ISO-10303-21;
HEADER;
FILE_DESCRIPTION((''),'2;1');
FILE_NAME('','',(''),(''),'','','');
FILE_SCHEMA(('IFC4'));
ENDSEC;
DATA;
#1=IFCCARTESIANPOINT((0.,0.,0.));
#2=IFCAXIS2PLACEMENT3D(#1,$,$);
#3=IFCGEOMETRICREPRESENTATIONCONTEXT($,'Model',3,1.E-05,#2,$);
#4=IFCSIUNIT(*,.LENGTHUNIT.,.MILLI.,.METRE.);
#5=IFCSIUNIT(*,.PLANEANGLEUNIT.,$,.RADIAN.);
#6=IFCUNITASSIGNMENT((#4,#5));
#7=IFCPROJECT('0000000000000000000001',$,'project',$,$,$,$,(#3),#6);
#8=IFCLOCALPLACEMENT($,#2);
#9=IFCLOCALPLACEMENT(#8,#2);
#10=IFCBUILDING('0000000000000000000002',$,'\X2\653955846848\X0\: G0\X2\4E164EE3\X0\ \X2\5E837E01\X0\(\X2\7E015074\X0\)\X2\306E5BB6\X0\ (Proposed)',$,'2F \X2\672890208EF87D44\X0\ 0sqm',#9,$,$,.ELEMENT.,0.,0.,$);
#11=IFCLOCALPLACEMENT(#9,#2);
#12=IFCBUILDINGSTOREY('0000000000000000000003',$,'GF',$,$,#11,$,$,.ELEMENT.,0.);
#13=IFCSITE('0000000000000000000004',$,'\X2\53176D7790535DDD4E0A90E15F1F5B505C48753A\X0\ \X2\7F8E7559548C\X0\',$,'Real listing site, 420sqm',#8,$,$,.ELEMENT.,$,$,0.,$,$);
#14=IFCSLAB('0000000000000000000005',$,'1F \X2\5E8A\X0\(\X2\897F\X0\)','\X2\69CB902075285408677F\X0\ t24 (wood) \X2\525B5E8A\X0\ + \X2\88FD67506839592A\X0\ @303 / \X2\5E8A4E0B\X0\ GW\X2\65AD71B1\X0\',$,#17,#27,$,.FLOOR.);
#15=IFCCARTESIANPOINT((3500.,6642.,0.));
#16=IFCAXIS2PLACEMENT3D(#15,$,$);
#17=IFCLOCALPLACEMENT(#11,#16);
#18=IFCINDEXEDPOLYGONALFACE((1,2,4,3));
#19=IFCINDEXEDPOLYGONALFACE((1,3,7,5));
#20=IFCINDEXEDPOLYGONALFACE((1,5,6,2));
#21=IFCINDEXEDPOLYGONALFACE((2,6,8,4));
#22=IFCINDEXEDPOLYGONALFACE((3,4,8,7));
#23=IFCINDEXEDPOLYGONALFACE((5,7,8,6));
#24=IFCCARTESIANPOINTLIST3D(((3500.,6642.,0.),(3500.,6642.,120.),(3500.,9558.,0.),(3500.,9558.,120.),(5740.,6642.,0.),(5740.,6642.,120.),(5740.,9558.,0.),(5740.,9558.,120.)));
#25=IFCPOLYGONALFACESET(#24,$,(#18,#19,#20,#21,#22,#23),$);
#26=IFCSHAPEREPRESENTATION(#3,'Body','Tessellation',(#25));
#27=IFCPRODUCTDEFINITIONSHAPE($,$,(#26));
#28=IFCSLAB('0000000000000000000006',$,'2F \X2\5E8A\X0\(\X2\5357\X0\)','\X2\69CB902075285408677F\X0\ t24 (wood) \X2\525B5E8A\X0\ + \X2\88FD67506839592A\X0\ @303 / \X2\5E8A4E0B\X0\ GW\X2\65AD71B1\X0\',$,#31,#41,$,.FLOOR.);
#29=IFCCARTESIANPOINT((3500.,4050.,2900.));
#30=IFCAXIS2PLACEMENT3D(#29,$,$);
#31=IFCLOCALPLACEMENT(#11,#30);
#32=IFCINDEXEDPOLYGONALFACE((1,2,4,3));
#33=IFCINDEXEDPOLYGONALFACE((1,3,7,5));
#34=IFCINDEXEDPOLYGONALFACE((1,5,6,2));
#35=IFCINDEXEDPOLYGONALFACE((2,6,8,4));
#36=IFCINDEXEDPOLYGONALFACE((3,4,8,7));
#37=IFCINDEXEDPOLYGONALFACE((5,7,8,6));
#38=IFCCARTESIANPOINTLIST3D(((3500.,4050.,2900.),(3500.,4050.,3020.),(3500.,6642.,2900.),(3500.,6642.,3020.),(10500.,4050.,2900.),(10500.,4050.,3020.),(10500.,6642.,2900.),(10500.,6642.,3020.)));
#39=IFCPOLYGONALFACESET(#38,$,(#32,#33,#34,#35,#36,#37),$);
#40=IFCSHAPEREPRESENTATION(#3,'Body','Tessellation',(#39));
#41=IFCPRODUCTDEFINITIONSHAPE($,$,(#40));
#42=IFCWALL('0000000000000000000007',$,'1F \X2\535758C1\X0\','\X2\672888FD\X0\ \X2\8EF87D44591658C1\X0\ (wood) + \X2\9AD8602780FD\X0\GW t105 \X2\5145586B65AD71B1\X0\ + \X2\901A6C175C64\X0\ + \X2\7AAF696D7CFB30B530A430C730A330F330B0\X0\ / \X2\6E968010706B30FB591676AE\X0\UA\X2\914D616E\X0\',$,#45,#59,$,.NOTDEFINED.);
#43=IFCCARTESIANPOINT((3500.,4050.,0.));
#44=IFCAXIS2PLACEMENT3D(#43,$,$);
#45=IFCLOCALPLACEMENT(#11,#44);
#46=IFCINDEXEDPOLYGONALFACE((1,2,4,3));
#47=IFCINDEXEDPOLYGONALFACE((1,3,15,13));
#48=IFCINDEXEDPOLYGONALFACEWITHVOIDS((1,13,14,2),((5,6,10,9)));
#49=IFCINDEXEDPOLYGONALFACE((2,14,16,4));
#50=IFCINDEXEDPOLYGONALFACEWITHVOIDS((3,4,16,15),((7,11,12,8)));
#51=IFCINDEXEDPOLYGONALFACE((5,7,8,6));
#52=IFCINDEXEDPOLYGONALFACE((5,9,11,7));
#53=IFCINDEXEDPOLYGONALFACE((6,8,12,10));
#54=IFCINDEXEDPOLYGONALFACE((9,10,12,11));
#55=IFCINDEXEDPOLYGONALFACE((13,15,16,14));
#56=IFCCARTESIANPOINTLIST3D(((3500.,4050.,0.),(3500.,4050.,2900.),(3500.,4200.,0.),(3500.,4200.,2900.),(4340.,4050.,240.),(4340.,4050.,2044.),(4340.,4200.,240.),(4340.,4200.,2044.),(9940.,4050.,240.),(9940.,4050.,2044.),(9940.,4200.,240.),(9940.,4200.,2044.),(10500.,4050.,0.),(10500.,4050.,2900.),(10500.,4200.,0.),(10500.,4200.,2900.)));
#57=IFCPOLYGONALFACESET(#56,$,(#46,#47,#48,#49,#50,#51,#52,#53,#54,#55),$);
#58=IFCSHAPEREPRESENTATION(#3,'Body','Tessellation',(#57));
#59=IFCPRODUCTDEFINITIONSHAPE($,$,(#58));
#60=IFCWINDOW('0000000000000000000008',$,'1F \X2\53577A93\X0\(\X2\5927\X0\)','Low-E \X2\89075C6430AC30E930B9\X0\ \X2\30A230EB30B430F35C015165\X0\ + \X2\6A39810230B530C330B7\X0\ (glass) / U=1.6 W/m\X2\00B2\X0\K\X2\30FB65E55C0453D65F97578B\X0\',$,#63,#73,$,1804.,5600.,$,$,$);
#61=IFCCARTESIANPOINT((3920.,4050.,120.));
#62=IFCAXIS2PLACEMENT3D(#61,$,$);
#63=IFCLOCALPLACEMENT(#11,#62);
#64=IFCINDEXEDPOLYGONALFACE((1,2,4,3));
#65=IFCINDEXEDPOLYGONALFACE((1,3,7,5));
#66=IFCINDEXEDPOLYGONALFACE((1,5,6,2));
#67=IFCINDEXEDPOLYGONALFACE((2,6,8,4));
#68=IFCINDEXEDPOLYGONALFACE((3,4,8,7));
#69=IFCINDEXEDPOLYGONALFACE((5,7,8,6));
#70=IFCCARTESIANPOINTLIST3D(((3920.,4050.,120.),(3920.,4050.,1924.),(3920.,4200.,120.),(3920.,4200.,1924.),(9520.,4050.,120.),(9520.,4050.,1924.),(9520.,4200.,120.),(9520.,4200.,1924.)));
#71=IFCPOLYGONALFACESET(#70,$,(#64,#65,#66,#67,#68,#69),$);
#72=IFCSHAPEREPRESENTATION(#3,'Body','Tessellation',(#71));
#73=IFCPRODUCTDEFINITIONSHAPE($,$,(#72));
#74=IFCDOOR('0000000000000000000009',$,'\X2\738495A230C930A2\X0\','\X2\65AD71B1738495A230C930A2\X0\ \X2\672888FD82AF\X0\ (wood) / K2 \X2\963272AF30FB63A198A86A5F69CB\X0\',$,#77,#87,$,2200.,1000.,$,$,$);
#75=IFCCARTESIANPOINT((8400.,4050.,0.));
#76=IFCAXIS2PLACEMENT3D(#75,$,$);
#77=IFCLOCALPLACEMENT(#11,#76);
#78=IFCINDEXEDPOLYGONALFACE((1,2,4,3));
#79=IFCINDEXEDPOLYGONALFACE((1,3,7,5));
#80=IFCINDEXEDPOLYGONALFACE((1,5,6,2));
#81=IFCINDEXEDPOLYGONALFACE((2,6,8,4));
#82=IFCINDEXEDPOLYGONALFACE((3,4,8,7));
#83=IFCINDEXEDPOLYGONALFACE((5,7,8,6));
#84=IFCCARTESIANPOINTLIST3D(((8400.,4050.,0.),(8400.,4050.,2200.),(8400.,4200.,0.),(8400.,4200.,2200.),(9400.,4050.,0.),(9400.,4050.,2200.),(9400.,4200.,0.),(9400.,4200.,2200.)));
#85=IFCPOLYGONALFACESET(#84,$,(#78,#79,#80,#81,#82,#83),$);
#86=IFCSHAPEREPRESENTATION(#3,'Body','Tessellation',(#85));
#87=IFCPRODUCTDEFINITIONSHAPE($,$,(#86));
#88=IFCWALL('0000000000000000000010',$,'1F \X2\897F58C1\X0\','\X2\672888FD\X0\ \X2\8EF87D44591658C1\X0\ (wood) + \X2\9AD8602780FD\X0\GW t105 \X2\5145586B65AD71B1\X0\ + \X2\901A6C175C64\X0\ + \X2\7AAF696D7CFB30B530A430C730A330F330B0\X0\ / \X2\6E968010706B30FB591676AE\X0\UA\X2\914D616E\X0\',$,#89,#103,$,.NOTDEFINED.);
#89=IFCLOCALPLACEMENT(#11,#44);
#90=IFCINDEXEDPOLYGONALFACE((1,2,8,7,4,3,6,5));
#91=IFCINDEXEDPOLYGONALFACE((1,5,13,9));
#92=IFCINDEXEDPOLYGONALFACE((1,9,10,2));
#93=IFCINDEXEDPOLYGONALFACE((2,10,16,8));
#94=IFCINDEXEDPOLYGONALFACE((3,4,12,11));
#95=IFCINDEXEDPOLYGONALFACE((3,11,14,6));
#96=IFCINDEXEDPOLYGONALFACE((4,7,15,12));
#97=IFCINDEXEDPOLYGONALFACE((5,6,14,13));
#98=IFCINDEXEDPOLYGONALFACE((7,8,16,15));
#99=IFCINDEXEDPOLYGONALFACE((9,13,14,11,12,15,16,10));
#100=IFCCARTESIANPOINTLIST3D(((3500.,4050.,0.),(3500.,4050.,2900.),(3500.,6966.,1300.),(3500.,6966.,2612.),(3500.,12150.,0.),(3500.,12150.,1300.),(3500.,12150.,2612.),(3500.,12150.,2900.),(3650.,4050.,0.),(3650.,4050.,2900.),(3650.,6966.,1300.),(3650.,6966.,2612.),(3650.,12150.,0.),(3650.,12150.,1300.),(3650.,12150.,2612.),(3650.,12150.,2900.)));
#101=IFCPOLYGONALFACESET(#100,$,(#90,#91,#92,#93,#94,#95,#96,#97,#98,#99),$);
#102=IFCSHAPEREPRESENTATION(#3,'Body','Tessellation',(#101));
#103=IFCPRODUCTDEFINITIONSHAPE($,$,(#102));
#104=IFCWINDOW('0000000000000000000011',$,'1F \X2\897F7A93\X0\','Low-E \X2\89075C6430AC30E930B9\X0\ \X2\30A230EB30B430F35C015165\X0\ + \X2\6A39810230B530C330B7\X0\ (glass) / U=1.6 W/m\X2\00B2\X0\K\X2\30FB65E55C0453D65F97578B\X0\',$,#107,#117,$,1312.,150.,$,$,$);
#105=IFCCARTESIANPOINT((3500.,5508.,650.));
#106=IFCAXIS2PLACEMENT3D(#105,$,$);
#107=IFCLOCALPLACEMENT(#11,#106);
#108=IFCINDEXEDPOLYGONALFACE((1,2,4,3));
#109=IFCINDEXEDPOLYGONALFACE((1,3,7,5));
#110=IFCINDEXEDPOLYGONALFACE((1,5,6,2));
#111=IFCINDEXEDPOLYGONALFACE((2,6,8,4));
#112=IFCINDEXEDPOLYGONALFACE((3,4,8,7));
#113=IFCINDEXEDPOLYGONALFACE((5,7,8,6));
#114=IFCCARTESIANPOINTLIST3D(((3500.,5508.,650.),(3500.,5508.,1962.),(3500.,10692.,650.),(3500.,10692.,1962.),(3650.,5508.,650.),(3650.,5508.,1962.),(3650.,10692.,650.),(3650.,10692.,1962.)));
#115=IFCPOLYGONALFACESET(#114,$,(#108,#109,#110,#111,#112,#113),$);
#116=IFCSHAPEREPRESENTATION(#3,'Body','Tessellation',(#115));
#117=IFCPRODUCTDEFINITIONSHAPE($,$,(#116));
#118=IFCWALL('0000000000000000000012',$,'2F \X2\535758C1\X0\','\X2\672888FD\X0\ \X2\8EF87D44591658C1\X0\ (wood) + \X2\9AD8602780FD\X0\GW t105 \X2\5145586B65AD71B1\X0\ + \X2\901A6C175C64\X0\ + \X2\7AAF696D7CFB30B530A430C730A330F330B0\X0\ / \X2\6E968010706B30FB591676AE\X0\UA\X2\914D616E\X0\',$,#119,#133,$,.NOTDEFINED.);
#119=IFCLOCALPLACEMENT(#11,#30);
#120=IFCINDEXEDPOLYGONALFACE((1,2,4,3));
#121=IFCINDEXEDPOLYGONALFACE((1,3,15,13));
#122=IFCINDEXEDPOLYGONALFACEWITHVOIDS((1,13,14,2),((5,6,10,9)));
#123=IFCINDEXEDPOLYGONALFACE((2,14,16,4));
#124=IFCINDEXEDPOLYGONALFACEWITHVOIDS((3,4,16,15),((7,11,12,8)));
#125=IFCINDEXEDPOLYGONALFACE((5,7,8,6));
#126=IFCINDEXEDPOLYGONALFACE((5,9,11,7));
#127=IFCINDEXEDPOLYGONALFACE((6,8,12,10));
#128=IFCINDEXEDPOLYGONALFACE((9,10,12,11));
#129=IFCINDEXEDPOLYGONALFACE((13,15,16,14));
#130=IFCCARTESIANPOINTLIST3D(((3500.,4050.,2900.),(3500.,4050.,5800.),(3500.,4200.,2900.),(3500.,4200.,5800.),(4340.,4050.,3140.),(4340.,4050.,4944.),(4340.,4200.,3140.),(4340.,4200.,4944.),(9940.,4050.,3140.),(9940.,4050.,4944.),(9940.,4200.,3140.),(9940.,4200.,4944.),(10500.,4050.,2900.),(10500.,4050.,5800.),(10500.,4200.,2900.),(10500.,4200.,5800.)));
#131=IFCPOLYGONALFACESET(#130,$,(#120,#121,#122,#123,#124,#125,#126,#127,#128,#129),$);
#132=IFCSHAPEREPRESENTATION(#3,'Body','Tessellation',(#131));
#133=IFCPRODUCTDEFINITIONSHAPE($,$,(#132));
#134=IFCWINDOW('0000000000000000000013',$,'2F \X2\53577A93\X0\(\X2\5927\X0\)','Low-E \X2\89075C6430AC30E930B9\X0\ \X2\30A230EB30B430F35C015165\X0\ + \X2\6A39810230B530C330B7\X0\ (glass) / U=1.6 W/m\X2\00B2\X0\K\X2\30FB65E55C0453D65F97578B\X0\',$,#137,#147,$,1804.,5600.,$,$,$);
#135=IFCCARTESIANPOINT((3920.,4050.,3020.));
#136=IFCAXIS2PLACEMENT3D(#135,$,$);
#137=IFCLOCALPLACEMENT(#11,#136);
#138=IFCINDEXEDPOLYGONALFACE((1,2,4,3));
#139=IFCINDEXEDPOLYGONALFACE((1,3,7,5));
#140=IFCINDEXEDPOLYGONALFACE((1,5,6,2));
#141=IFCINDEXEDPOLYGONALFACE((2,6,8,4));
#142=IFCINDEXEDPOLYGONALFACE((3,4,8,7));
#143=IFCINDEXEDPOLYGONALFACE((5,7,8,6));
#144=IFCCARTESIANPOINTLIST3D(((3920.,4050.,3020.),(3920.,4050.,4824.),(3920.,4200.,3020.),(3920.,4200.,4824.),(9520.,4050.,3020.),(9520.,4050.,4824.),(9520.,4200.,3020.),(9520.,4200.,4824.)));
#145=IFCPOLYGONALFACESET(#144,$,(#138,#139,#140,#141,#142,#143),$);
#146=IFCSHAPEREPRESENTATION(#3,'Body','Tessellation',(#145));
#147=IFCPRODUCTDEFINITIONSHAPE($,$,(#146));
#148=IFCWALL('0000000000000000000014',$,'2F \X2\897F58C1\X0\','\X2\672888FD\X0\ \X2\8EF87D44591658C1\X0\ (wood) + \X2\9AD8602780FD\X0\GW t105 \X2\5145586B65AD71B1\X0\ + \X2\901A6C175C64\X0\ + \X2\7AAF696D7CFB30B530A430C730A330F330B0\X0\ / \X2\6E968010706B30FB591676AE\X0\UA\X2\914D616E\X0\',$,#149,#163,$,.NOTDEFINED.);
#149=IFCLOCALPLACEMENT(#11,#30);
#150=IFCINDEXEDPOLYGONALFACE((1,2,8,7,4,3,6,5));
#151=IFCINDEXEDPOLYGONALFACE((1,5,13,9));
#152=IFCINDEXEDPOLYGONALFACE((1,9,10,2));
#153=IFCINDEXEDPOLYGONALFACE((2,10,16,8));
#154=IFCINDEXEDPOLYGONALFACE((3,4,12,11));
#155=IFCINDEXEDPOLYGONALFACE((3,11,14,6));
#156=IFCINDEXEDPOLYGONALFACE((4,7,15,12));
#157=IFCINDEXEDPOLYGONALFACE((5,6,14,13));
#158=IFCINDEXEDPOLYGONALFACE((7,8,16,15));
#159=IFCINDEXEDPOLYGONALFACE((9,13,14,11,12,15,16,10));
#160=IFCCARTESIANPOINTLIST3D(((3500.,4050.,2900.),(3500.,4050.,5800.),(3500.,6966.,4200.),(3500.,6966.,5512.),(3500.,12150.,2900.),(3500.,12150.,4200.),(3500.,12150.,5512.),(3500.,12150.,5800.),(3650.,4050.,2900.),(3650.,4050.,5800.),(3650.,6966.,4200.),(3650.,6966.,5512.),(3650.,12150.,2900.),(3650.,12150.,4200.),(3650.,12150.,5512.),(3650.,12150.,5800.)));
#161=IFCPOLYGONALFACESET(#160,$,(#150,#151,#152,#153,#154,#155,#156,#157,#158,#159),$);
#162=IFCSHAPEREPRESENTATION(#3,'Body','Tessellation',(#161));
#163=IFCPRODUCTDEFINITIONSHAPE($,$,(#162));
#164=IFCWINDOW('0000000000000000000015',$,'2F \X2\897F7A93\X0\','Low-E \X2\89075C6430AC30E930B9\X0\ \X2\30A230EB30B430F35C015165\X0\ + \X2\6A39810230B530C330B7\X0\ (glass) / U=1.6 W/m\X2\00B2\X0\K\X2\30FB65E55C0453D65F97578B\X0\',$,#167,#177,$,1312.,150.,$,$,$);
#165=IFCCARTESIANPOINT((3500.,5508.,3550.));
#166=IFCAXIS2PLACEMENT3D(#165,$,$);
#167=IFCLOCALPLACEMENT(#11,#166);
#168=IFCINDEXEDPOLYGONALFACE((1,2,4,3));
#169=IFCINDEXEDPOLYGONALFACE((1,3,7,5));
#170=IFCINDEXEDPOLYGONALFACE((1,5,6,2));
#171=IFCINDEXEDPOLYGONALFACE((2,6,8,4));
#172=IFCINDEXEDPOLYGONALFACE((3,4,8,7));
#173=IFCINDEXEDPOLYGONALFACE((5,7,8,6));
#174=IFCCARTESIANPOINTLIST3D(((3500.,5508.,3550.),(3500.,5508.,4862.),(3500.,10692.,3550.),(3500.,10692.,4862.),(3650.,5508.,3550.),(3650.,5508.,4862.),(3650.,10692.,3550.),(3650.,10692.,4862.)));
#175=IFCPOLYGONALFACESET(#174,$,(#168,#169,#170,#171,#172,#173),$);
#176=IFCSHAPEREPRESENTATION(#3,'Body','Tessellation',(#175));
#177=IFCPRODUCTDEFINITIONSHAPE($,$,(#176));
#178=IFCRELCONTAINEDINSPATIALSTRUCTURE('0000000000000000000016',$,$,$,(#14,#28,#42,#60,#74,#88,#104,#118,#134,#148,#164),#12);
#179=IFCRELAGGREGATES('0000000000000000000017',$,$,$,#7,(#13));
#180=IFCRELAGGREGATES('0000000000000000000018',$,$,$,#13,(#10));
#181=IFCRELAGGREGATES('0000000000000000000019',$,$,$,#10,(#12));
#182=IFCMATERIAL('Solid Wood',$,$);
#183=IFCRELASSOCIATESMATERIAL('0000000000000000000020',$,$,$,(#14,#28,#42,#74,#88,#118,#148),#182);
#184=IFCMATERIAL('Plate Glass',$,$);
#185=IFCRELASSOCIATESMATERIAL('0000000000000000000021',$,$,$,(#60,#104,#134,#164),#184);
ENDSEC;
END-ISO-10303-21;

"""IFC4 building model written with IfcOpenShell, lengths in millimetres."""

from ifc_helpers import new_model, si_unit, frame, frame_2d, origin, place, context, project, spatial, rectangle, extrude, material, element, fill, save


model = new_model("IFC4")

# Units and contexts
model_context = context("Model", 3, precision=1e-05, world=origin())
ifc_project = project(units=[si_unit("LENGTHUNIT", "METRE", prefix="MILLI"), si_unit("PLANEANGLEUNIT", "RADIAN")], contexts=[model_context])

# Site, building, storey
site_placement = place(None, origin())
site = spatial("IfcSite", under=ifc_project, at=site_placement, Name="北海道川上郡弟子屈町 美留和", ObjectType="Real listing site, 420sqm", CompositionType="ELEMENT", RefElevation=0.0)
building_placement = place(site_placement, origin())
building = spatial("IfcBuilding", under=site, at=building_placement, Name="改善案: G0世代 広縁(縁側)の家 (Proposed)", ObjectType="2F 木造軸組 0sqm", CompositionType="ELEMENT", ElevationOfRefHeight=0.0, ElevationOfTerrain=0.0)
storey_placement = place(building_placement, origin())
storey = spatial("IfcBuildingStorey", under=building, at=storey_placement, Name="GF", CompositionType="ELEMENT", Elevation=0.0)

# Slabs
ifc_material_1 = material(Name="Solid Wood")
slab_1_placement = place(storey_placement, frame((3500.0, 6642.0, 0.0)))
element("IfcSlab", 1, at=slab_1_placement, inside=storey, material=ifc_material_1, Name="1F 床(西)", Description="構造用合板 t24 (wood) 剛床 + 製材根太 @303 / 床下 GW断熱", PredefinedType="FLOOR", context=model_context, shape_type="SweptSolid", body=[
    extrude(rectangle(XDim=2240.0, YDim=2916.0, at=frame_2d((1120.0, 1458.0))), frame((3500.0, 6642.0, 0.0)), (0.0, 0.0, 1.0), 120.0),
])
slab_2_placement = place(storey_placement, frame((3500.0, 4050.0, 2900.0)))
element("IfcSlab", 2, at=slab_2_placement, inside=storey, material=ifc_material_1, Name="2F 床(南)", Description="構造用合板 t24 (wood) 剛床 + 製材根太 @303 / 床下 GW断熱", PredefinedType="FLOOR", context=model_context, shape_type="SweptSolid", body=[
    extrude(rectangle(XDim=7000.0, YDim=2592.0, at=frame_2d((3500.0, 1296.0))), frame((3500.0, 4050.0, 2900.0)), (0.0, 0.0, 1.0), 120.0),
])

# Wall, openings, window, door
wall_1_placement = place(storey_placement, frame((3500.0, 4050.0, 0.0)))
wall_1 = element("IfcWall", 3, at=wall_1_placement, inside=storey, material=ifc_material_1, Name="1F 南壁", Description="木製 軸組外壁 (wood) + 高性能GW t105 充填断熱 + 通気層 + 窯業系サイディング / 準耐火・外皮UA配慮", PredefinedType="NOTDEFINED", context=model_context, shape_type="SweptSolid", body=[
    extrude(rectangle(XDim=7000.0, YDim=150.0, at=frame_2d((3500.0, 75.0))), frame((3500.0, 4050.0, 0.0)), (0.0, 0.0, 1.0), 2900.0),
])
opening_1_placement = place(storey_placement, frame((3920.0, 4050.0, 120.0)))
opening_1 = element("IfcOpeningElement", 4, at=opening_1_placement, cuts=wall_1, PredefinedType="NOTDEFINED", context=model_context, shape_type="SweptSolid", body=[
    extrude(rectangle(XDim=5600.0, YDim=150.0, at=frame_2d((2800.0, 75.0))), frame((3920.0, 4050.0, 120.0)), (0.0, 0.0, 1.0), 1804.0),
])
opening_2_placement = place(storey_placement, frame((8400.0, 4050.0, 0.0)))
opening_2 = element("IfcOpeningElement", 5, at=opening_2_placement, cuts=wall_1, PredefinedType="NOTDEFINED", context=model_context, shape_type="SweptSolid", body=[
    extrude(rectangle(XDim=1000.0, YDim=150.0, at=frame_2d((500.0, 75.0))), frame((8400.0, 4050.0, 0.0)), (0.0, 0.0, 1.0), 2200.0),
])
ifc_material_2 = material(Name="Plate Glass")
window_1_placement = place(storey_placement, frame((3920.0, 4050.0, 120.0)))
window_1 = element("IfcWindow", 6, at=window_1_placement, inside=storey, material=ifc_material_2, Name="1F 南窓(大)", Description="Low-E 複層ガラス アルゴン封入 + 樹脂サッシ (glass) / U=1.6 W/m²K・日射取得型", OverallHeight=1804.0, OverallWidth=5600.0, context=model_context, shape_type="SweptSolid", body=[
    extrude(rectangle(XDim=5600.0, YDim=150.0, at=frame_2d((2800.0, 75.0))), frame((3920.0, 4050.0, 120.0)), (0.0, 0.0, 1.0), 1804.0),
])
fill(opening_1, window_1)
door_placement = place(storey_placement, frame((8400.0, 4050.0, 0.0)))
door = element("IfcDoor", 7, at=door_placement, inside=storey, material=ifc_material_1, Name="玄関ドア", Description="断熱玄関ドア 木製芯 (wood) / K2 防犯・採風機構", OverallHeight=2200.0, OverallWidth=1000.0, context=model_context, shape_type="SweptSolid", body=[
    extrude(rectangle(XDim=1000.0, YDim=150.0, at=frame_2d((500.0, 75.0))), frame((8400.0, 4050.0, 0.0)), (0.0, 0.0, 1.0), 2200.0),
])
fill(opening_2, door)

# Walls, openings, windows
wall_2_placement = place(storey_placement, frame((3500.0, 4050.0, 0.0)))
wall_2 = element("IfcWall", 8, at=wall_2_placement, inside=storey, material=ifc_material_1, Name="1F 西壁", Description="木製 軸組外壁 (wood) + 高性能GW t105 充填断熱 + 通気層 + 窯業系サイディング / 準耐火・外皮UA配慮", PredefinedType="NOTDEFINED", context=model_context, shape_type="SweptSolid", body=[
    extrude(rectangle(XDim=150.0, YDim=8100.0, at=frame_2d((75.0, 4050.0))), frame((3500.0, 4050.0, 0.0)), (0.0, 0.0, 1.0), 2900.0),
])
opening_3_placement = place(storey_placement, frame((3500.0, 5508.0, 650.0)))
opening_3 = element("IfcOpeningElement", 9, at=opening_3_placement, cuts=wall_2, PredefinedType="NOTDEFINED", context=model_context, shape_type="SweptSolid", body=[
    extrude(rectangle(XDim=150.0, YDim=5184.0, at=frame_2d((75.0, 2592.0))), frame((3500.0, 5508.0, 650.0)), (0.0, 0.0, 1.0), 1312.0),
])
window_2_placement = place(storey_placement, frame((3500.0, 5508.0, 650.0)))
window_2 = element("IfcWindow", 10, at=window_2_placement, inside=storey, material=ifc_material_2, Name="1F 西窓", Description="Low-E 複層ガラス アルゴン封入 + 樹脂サッシ (glass) / U=1.6 W/m²K・日射取得型", OverallHeight=1312.0, OverallWidth=150.0, context=model_context, shape_type="SweptSolid", body=[
    extrude(rectangle(XDim=150.0, YDim=5184.0, at=frame_2d((75.0, 2592.0))), frame((3500.0, 5508.0, 650.0)), (0.0, 0.0, 1.0), 1312.0),
])
fill(opening_3, window_2)
wall_3_placement = place(storey_placement, frame((3500.0, 4050.0, 2900.0)))
wall_3 = element("IfcWall", 11, at=wall_3_placement, inside=storey, material=ifc_material_1, Name="2F 南壁", Description="木製 軸組外壁 (wood) + 高性能GW t105 充填断熱 + 通気層 + 窯業系サイディング / 準耐火・外皮UA配慮", PredefinedType="NOTDEFINED", context=model_context, shape_type="SweptSolid", body=[
    extrude(rectangle(XDim=7000.0, YDim=150.0, at=frame_2d((3500.0, 75.0))), frame((3500.0, 4050.0, 2900.0)), (0.0, 0.0, 1.0), 2900.0),
])
opening_4_placement = place(storey_placement, frame((3920.0, 4050.0, 3020.0)))
opening_4 = element("IfcOpeningElement", 12, at=opening_4_placement, cuts=wall_3, PredefinedType="NOTDEFINED", context=model_context, shape_type="SweptSolid", body=[
    extrude(rectangle(XDim=5600.0, YDim=150.0, at=frame_2d((2800.0, 75.0))), frame((3920.0, 4050.0, 3020.0)), (0.0, 0.0, 1.0), 1804.0),
])
window_3_placement = place(storey_placement, frame((3920.0, 4050.0, 3020.0)))
window_3 = element("IfcWindow", 13, at=window_3_placement, inside=storey, material=ifc_material_2, Name="2F 南窓(大)", Description="Low-E 複層ガラス アルゴン封入 + 樹脂サッシ (glass) / U=1.6 W/m²K・日射取得型", OverallHeight=1804.0, OverallWidth=5600.0, context=model_context, shape_type="SweptSolid", body=[
    extrude(rectangle(XDim=5600.0, YDim=150.0, at=frame_2d((2800.0, 75.0))), frame((3920.0, 4050.0, 3020.0)), (0.0, 0.0, 1.0), 1804.0),
])
fill(opening_4, window_3)
wall_4_placement = place(storey_placement, frame((3500.0, 4050.0, 2900.0)))
wall_4 = element("IfcWall", 14, at=wall_4_placement, inside=storey, material=ifc_material_1, Name="2F 西壁", Description="木製 軸組外壁 (wood) + 高性能GW t105 充填断熱 + 通気層 + 窯業系サイディング / 準耐火・外皮UA配慮", PredefinedType="NOTDEFINED", context=model_context, shape_type="SweptSolid", body=[
    extrude(rectangle(XDim=150.0, YDim=8100.0, at=frame_2d((75.0, 4050.0))), frame((3500.0, 4050.0, 2900.0)), (0.0, 0.0, 1.0), 2900.0),
])
opening_5_placement = place(storey_placement, frame((3500.0, 5508.0, 3550.0)))
opening_5 = element("IfcOpeningElement", 15, at=opening_5_placement, cuts=wall_4, PredefinedType="NOTDEFINED", context=model_context, shape_type="SweptSolid", body=[
    extrude(rectangle(XDim=150.0, YDim=5184.0, at=frame_2d((75.0, 2592.0))), frame((3500.0, 5508.0, 3550.0)), (0.0, 0.0, 1.0), 1312.0),
])
window_4_placement = place(storey_placement, frame((3500.0, 5508.0, 3550.0)))
window_4 = element("IfcWindow", 16, at=window_4_placement, inside=storey, material=ifc_material_2, Name="2F 西窓", Description="Low-E 複層ガラス アルゴン封入 + 樹脂サッシ (glass) / U=1.6 W/m²K・日射取得型", OverallHeight=1312.0, OverallWidth=150.0, context=model_context, shape_type="SweptSolid", body=[
    extrude(rectangle(XDim=150.0, YDim=5184.0, at=frame_2d((75.0, 2592.0))), frame((3500.0, 5508.0, 3550.0)), (0.0, 0.0, 1.0), 1312.0),
])
fill(opening_5, window_4)

save(model, "model.ifc")
